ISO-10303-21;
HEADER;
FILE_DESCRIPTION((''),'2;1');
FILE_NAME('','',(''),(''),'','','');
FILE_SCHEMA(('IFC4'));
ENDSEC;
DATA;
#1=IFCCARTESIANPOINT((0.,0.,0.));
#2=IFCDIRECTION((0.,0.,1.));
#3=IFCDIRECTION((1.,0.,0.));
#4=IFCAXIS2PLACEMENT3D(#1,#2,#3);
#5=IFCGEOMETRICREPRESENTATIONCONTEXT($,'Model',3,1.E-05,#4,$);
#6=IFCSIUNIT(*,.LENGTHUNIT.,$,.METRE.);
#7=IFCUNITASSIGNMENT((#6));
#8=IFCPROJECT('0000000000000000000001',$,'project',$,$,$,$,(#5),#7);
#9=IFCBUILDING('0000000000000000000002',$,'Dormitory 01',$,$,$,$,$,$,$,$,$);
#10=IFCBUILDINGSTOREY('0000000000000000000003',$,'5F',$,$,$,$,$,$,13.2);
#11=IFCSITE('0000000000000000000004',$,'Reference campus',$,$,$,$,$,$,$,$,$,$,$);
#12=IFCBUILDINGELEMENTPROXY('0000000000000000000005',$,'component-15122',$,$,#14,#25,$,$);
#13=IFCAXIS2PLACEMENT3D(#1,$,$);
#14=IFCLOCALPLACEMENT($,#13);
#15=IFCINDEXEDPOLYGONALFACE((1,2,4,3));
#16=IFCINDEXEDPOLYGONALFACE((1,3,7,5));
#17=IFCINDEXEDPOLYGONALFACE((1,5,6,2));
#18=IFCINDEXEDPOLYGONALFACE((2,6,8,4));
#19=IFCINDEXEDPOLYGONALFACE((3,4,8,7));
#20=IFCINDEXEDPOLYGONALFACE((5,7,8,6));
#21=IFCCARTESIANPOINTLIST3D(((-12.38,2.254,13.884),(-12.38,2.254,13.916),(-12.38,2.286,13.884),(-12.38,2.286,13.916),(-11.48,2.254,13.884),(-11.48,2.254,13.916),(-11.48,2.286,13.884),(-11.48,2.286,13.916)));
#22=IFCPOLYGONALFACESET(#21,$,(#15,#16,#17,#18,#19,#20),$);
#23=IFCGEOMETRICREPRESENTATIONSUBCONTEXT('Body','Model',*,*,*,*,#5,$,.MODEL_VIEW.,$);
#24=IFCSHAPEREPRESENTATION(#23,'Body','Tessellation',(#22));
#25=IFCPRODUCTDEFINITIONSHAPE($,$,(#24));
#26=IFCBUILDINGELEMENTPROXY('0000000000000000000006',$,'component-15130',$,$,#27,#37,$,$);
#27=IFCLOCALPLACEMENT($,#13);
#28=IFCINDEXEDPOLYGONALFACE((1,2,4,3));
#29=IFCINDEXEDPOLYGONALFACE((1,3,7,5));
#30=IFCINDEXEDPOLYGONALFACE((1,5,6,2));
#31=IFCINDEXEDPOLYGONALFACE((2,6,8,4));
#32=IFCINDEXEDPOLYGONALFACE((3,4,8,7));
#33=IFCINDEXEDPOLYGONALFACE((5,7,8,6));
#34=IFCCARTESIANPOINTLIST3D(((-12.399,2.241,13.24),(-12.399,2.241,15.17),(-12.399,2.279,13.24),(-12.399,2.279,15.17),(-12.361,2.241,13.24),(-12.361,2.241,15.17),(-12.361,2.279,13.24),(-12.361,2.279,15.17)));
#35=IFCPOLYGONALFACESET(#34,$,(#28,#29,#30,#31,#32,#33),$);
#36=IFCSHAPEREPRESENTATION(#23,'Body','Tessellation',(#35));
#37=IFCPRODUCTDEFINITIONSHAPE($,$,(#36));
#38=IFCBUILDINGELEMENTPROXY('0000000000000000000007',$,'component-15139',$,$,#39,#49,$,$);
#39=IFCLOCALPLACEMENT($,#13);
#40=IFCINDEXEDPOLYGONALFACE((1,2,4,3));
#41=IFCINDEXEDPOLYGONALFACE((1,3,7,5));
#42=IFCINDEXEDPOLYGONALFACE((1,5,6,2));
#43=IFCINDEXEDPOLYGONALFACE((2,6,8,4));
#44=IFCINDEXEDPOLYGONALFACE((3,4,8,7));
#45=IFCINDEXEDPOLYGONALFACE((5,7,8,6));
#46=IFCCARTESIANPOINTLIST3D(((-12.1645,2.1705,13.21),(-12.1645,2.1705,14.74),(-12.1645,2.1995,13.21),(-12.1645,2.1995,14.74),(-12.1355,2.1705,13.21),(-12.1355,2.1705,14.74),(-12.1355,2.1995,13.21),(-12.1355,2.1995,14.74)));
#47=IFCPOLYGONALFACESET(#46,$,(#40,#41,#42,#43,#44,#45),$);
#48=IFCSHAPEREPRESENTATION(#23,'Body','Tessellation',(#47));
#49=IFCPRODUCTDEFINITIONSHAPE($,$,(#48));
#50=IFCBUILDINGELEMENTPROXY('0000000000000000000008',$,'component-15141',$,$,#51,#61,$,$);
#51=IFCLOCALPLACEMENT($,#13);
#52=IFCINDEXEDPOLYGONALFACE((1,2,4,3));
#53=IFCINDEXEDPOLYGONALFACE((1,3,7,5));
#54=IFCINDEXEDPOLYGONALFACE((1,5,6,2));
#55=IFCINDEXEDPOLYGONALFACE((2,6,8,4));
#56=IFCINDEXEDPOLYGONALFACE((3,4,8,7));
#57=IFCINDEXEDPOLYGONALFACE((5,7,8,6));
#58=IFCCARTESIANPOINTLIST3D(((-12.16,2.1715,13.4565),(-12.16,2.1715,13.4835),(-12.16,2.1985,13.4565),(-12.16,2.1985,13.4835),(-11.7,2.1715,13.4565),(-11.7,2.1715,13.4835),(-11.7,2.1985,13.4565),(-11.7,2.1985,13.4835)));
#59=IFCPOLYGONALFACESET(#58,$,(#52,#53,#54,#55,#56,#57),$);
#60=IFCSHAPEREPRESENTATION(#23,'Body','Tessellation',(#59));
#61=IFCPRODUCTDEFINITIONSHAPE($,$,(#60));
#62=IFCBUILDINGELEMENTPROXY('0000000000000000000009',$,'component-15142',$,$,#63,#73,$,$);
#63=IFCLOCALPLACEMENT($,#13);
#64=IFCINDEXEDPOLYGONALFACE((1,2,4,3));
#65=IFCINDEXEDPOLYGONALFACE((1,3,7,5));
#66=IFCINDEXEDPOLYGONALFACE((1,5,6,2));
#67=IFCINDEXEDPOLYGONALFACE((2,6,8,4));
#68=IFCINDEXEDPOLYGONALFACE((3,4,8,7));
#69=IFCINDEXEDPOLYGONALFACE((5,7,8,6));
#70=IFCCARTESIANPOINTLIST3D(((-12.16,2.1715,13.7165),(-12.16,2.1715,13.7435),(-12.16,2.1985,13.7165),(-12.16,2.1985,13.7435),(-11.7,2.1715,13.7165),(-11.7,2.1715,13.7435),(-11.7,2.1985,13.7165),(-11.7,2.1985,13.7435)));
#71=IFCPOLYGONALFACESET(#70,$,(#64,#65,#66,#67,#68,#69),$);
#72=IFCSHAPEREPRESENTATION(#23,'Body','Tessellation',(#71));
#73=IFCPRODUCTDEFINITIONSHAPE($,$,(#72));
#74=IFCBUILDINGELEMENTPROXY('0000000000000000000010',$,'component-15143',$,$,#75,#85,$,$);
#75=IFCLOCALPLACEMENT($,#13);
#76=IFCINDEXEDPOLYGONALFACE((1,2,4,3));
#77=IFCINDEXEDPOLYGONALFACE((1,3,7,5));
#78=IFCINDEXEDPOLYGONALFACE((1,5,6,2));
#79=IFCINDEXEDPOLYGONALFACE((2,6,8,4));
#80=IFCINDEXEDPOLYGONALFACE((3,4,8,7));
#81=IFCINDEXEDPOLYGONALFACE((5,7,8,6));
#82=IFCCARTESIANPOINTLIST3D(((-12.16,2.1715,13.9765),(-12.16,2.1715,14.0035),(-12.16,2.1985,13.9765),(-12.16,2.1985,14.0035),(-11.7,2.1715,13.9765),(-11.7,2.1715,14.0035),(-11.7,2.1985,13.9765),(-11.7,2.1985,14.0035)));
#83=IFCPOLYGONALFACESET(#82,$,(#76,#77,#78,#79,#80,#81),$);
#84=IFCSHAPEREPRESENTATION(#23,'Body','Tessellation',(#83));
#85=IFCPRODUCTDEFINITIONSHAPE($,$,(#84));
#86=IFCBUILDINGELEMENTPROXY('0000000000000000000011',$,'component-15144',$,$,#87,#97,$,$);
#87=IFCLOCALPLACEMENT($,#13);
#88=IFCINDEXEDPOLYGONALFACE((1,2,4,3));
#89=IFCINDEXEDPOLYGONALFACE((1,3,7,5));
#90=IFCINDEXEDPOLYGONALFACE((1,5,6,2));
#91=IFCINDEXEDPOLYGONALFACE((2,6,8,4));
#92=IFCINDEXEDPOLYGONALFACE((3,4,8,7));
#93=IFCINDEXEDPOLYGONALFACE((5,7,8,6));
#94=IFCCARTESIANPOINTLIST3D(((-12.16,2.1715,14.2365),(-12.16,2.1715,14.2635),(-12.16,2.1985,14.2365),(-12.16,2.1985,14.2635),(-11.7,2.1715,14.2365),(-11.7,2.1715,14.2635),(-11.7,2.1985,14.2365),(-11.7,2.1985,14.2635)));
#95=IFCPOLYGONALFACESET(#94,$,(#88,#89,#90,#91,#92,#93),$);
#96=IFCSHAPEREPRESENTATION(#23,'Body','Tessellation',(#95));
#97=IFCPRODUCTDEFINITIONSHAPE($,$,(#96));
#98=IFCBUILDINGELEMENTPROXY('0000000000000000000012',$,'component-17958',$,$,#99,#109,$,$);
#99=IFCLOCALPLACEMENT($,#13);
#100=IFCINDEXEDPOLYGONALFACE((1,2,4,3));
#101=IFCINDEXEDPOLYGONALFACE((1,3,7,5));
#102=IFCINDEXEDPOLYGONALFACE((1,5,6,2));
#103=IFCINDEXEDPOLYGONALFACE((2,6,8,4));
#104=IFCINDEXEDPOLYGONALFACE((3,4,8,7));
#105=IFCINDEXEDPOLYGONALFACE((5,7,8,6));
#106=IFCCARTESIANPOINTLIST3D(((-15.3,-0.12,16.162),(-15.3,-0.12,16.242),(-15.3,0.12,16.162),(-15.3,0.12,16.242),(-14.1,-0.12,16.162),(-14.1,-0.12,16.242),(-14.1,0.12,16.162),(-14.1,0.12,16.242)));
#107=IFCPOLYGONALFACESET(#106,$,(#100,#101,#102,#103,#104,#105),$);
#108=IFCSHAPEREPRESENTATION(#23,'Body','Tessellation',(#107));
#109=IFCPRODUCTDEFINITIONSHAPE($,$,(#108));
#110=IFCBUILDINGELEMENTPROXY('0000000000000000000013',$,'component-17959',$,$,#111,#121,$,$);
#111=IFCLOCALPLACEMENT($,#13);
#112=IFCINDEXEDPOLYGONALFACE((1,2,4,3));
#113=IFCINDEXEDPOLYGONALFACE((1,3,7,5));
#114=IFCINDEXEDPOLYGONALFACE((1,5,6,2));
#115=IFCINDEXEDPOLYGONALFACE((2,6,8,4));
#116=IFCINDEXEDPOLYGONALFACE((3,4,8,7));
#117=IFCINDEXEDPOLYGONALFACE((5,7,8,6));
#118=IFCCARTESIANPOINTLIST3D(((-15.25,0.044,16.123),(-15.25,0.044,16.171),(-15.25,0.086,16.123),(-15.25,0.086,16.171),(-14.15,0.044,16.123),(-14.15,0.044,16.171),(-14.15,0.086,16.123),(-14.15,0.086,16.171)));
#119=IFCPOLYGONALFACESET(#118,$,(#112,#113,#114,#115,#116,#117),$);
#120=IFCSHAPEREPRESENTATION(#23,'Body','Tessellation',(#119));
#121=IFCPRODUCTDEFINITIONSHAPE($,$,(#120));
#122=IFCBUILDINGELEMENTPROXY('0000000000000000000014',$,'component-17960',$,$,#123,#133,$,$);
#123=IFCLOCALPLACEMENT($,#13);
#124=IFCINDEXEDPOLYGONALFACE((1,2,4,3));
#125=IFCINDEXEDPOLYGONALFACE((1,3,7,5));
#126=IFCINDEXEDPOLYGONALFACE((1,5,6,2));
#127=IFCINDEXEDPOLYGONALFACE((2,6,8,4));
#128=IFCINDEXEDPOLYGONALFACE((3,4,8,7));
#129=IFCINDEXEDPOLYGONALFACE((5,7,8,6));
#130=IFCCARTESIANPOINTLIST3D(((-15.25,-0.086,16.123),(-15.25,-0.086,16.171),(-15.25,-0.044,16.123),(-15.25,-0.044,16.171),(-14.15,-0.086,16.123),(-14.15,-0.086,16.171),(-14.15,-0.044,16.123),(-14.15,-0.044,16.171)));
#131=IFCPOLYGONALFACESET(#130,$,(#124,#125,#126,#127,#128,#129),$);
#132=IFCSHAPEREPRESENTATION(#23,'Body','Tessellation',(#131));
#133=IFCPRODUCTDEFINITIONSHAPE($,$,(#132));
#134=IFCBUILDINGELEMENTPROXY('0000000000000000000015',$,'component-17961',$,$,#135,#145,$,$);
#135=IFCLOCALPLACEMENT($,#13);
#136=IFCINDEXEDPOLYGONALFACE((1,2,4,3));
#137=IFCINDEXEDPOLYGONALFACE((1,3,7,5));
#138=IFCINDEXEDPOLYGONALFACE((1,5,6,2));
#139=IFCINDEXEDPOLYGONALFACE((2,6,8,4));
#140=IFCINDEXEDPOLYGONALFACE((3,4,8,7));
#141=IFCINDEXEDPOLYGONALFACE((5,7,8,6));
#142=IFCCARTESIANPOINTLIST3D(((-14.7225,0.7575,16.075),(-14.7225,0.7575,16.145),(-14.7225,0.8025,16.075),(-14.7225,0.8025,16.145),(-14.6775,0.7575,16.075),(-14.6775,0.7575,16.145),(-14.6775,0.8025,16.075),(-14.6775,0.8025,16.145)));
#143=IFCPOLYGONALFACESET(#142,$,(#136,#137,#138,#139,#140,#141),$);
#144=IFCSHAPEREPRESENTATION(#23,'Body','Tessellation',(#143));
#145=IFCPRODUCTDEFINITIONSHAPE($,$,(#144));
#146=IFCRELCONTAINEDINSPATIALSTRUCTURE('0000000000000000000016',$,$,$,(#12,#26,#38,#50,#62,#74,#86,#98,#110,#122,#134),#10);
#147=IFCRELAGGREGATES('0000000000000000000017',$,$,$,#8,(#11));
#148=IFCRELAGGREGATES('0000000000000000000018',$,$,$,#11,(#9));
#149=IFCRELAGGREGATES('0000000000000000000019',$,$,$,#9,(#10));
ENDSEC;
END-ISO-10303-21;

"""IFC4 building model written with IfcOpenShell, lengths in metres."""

from ifc_helpers import new_model, si_unit, frame, origin, origin_with_axes, origin_2d, place, context, subcontext, project, spatial, rectangle, extrude, element, save


model = new_model("IFC4")

# Units and contexts
model_context = context("Model", 3, precision=1e-05, world=origin_with_axes())
body_context = subcontext(model_context, "Body", "Model", "MODEL_VIEW")
ifc_project = project(units=[si_unit("LENGTHUNIT", "METRE")], contexts=[model_context])

# Site, building, storey
site = spatial("IfcSite", under=ifc_project, Name="Reference campus")
building = spatial("IfcBuilding", under=site, Name="Dormitory 01")
storey = spatial("IfcBuildingStorey", under=building, Name="5F", Elevation=13.2)

# Building element proxies
proxy_1_placement = place(None, frame((-11.93, 2.27, 13.884), z_axis=(0.0, 0.0, 1.0), x_axis=(1.0, 0.0, 0.0)))
element("IfcBuildingElementProxy", 1, at=proxy_1_placement, inside=storey, Name="component-15122", context=body_context, shape_type="SweptSolid", body=[
    extrude(rectangle(XDim=0.9, YDim=0.032, at=origin_2d()), origin(), (0.0, 0.0, 1.0), 0.032),
])
proxy_2_placement = place(None, frame((-12.38, 2.26, 13.24), z_axis=(0.0, 0.0, 1.0), x_axis=(1.0, 0.0, 0.0)))
element("IfcBuildingElementProxy", 2, at=proxy_2_placement, inside=storey, Name="component-15130", context=body_context, shape_type="SweptSolid", body=[
    extrude(rectangle(XDim=0.038, YDim=0.038, at=origin_2d()), origin(), (0.0, 0.0, 1.0), 1.93),
])
proxy_3_placement = place(None, frame((-12.15, 2.185, 13.21), z_axis=(0.0, 0.0, 1.0), x_axis=(1.0, 0.0, 0.0)))
element("IfcBuildingElementProxy", 3, at=proxy_3_placement, inside=storey, Name="component-15139", context=body_context, shape_type="SweptSolid", body=[
    extrude(rectangle(XDim=0.029, YDim=0.029, at=origin_2d()), origin(), (0.0, 0.0, 1.0), 1.53),
])
for number, where, z_axis, x_axis, name in (
    (4, (-11.93, 2.185, 13.4565), (0.0, 0.0, 1.0), (1.0, 0.0, 0.0), "component-15141"),
    (5, (-11.93, 2.185, 13.7165), (0.0, 0.0, 1.0), (1.0, 0.0, 0.0), "component-15142"),
    (6, (-11.93, 2.185, 13.9765), (0.0, 0.0, 1.0), (1.0, 0.0, 0.0), "component-15143"),
    (7, (-11.93, 2.185, 14.2365), (0.0, 0.0, 1.0), (1.0, 0.0, 0.0), "component-15144"),
):
    element("IfcBuildingElementProxy", number, at=place(None, frame(where, z_axis=z_axis, x_axis=x_axis)), inside=storey, Name=name, context=body_context, shape_type="SweptSolid", body=[
        extrude(rectangle(XDim=0.46, YDim=0.027, at=origin_2d()), origin(), (0.0, 0.0, 1.0), 0.027),
    ])
proxy_4_placement = place(None, frame((-14.7, 0.0, 16.162), z_axis=(0.0, 0.0, 1.0), x_axis=(1.0, 0.0, 0.0)))
element("IfcBuildingElementProxy", 8, at=proxy_4_placement, inside=storey, Name="component-17958", context=body_context, shape_type="SweptSolid", body=[
    extrude(rectangle(XDim=1.2, YDim=0.24, at=origin_2d()), origin(), (0.0, 0.0, 1.0), 0.08),
])
for number, where, z_axis, x_axis, name in (
    (9, (-14.7, 0.065, 16.123), (0.0, 0.0, 1.0), (1.0, 0.0, 0.0), "component-17959"),
    (10, (-14.7, -0.065, 16.123), (0.0, 0.0, 1.0), (1.0, 0.0, 0.0), "component-17960"),
):
    element("IfcBuildingElementProxy", number, at=place(None, frame(where, z_axis=z_axis, x_axis=x_axis)), inside=storey, Name=name, context=body_context, shape_type="SweptSolid", body=[
        extrude(rectangle(XDim=1.1, YDim=0.042, at=origin_2d()), origin(), (0.0, 0.0, 1.0), 0.048),
    ])
proxy_5_placement = place(None, frame((-14.7, 0.78, 16.075), z_axis=(0.0, 0.0, 1.0), x_axis=(1.0, 0.0, 0.0)))
element("IfcBuildingElementProxy", 11, at=proxy_5_placement, inside=storey, Name="component-17961", context=body_context, shape_type="SweptSolid", body=[
    extrude(rectangle(XDim=0.045, YDim=0.045, at=origin_2d()), origin(), (0.0, 0.0, 1.0), 0.07),
])

save(model, "model.ifc")
